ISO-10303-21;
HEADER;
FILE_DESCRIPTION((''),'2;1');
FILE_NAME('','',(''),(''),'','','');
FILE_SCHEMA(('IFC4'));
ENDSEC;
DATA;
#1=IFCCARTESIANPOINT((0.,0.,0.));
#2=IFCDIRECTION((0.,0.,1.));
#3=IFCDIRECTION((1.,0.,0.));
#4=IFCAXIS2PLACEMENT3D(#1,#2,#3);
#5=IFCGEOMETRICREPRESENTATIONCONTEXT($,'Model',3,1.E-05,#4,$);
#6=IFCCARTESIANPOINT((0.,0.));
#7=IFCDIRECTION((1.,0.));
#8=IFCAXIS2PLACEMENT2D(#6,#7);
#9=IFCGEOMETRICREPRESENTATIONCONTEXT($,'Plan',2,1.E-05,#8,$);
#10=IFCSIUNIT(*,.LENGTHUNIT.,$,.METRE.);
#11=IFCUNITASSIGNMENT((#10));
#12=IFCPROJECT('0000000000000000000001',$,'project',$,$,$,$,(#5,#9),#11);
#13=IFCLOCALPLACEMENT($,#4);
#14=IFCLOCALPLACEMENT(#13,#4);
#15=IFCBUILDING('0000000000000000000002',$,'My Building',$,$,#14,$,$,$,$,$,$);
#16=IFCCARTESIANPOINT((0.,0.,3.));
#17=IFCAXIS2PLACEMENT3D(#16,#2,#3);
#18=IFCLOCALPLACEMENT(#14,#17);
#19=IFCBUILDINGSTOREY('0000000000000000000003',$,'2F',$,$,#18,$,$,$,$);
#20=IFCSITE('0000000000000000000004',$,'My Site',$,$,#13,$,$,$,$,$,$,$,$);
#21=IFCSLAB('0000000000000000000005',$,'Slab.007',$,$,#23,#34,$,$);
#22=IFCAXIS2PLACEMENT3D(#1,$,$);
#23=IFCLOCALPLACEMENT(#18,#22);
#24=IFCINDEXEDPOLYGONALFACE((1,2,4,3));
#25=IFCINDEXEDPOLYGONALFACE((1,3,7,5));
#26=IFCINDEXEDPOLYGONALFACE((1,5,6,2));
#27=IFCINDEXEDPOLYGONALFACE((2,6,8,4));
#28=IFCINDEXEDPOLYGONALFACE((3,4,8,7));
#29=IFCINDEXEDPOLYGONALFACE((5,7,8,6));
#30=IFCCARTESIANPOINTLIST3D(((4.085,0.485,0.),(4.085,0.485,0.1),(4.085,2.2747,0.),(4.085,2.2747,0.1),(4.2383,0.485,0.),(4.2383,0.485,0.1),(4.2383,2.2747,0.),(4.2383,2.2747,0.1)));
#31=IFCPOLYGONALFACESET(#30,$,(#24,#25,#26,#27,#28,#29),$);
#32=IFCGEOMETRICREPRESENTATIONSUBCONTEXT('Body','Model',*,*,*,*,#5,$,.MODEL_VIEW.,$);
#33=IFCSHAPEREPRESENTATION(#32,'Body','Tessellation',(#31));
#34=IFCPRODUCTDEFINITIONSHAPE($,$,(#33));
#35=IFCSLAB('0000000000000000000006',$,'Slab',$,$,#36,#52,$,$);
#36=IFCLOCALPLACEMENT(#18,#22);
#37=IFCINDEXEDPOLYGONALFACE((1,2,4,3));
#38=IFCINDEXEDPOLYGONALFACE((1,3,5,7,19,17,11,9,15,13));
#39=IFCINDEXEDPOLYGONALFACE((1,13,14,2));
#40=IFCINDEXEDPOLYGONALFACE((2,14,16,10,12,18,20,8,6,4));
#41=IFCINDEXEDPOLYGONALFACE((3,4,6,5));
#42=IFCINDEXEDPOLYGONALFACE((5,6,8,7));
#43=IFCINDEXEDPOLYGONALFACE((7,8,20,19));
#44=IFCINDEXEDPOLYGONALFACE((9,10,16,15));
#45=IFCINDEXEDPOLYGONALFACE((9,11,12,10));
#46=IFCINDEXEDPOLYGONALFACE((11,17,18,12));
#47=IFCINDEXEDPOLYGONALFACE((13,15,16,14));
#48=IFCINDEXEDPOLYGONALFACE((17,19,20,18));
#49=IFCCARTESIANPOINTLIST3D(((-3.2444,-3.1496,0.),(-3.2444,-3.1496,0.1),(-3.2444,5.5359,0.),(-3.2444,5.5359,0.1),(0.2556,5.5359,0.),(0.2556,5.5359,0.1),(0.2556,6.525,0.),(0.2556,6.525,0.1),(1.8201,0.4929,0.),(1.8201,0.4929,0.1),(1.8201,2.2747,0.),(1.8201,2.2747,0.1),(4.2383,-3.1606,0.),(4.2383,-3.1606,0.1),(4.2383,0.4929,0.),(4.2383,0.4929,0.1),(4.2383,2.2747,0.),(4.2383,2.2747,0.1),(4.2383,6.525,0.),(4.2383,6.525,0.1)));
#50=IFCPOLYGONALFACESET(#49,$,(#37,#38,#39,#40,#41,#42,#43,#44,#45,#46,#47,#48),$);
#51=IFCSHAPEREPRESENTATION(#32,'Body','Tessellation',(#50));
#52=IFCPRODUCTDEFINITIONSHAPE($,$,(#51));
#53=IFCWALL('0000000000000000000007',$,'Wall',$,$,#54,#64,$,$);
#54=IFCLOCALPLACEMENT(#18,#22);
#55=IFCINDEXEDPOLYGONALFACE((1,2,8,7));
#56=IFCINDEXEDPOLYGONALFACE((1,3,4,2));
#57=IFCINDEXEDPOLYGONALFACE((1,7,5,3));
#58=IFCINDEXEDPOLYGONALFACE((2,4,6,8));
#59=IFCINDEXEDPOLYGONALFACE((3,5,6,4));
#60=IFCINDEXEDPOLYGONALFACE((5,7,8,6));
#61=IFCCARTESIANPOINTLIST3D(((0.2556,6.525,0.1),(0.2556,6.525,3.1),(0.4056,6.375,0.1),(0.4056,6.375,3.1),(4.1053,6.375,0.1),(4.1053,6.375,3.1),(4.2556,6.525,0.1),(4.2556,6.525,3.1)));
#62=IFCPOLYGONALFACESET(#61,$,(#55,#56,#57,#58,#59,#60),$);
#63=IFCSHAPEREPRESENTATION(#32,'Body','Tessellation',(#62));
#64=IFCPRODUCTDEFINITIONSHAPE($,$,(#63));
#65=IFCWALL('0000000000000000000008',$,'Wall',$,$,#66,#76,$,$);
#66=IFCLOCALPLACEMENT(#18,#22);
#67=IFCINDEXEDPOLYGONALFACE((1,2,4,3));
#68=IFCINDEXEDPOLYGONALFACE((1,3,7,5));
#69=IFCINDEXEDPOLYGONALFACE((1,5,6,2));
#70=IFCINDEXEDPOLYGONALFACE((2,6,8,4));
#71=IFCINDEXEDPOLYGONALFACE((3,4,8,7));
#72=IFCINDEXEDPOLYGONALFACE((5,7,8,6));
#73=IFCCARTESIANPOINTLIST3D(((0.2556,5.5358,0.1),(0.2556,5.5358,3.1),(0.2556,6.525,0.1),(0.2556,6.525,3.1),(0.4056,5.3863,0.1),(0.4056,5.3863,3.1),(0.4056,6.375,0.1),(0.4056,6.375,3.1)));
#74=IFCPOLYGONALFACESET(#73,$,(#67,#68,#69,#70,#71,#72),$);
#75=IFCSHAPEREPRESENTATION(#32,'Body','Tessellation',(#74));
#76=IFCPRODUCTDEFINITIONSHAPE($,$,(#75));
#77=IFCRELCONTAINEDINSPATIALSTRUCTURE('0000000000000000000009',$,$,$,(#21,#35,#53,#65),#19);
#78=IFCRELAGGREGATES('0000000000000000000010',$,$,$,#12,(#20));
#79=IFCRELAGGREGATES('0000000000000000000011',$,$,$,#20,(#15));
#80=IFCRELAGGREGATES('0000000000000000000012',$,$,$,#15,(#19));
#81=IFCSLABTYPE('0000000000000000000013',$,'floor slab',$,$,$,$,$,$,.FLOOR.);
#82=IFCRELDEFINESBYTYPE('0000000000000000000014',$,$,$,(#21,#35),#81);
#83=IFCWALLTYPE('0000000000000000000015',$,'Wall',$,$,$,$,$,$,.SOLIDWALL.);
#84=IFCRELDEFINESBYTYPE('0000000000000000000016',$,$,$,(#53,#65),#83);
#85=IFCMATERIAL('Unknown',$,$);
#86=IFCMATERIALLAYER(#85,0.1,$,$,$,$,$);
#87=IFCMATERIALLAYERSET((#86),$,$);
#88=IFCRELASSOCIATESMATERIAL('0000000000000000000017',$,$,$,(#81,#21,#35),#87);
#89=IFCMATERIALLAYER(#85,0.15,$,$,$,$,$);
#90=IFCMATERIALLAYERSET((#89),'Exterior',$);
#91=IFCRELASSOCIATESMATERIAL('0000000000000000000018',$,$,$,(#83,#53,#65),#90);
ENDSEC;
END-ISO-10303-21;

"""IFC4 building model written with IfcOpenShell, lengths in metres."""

from ifc_helpers import new_model, si_unit, frame, origin_with_axes, origin_2d_with_axis, place, context, subcontext, project, spatial, line, indexed_curve, outline, extrude, material, layer, layer_set, layer_usage, type_object, element, save


model = new_model("IFC4")

# Units and contexts
model_context = context("Model", 3, precision=1e-05, world=origin_with_axes())
plan_context = context("Plan", 2, precision=1e-05, world=origin_2d_with_axis())
body_context_1 = subcontext(model_context, "Body", "Model", "MODEL_VIEW")
ifc_project = project(units=[si_unit("LENGTHUNIT", "METRE")], contexts=[model_context, plan_context])

# Site, building, storey
site_placement = place(None, origin_with_axes())
site = spatial("IfcSite", under=ifc_project, at=site_placement, Name="My Site")
building_placement = place(site_placement, origin_with_axes())
building = spatial("IfcBuilding", under=site, at=building_placement, Name="My Building")
storey_placement = place(building_placement, frame((0.0, 0.0, 3.0), z_axis=(0.0, 0.0, 1.0), x_axis=(1.0, 0.0, 0.0)))
storey = spatial("IfcBuildingStorey", under=building, at=storey_placement, Name="2F")

# Slabs
ifc_material = material(Name="Unknown")
ifc_layer_1 = layer(ifc_material, 0.1)
ifc_layer_set_1 = layer_set([ifc_layer_1])
ifc_layer_usage_1 = layer_usage(ifc_layer_set_1, "AXIS3", "POSITIVE", -0.1)
slab_type = type_object("IfcSlabType", Name="floor slab", PredefinedType="FLOOR", material=ifc_layer_set_1)
slab_1_placement = place(storey_placement, frame((4.2383, 2.2747, 0.1), z_axis=(0.0, 0.0, 1.0), x_axis=(1.0, 0.0, 0.0)))
element("IfcSlab", 1, at=slab_1_placement, inside=storey, type_object=slab_type, material=ifc_layer_usage_1, Name="Slab.007", context=body_context_1, shape_type="SweptSolid", body=[
    extrude(outline(indexed_curve([(0.0, 0.0), (0.0, -1.7897), (-0.1533, -1.7897), (-0.1533, 0.0), (0.0, 0.0)])), frame((0.0, 0.0, -0.1), z_axis=(0.0, 0.0, 1.0), x_axis=(1.0, 0.0, 0.0)), (0.0, 0.0, 1.0), 0.1),
])
ifc_layer_usage_2 = layer_usage(ifc_layer_set_1, "AXIS3", "POSITIVE", -0.1)
slab_2_placement = place(storey_placement, frame((4.2383, -3.1606, 0.1), z_axis=(0.0, 0.0, 1.0), x_axis=(1.0, 0.0, 0.0)))
element("IfcSlab", 2, at=slab_2_placement, inside=storey, type_object=slab_type, material=ifc_layer_usage_2, Name="Slab", context=body_context_1, shape_type="SweptSolid", body=[
    extrude(outline(indexed_curve([(0.0, 0.0), (0.0, 3.6536), (-2.4183, 3.6536), (-2.4183, 5.4353), (0.0, 5.4353), (0.0, 9.6856), (-3.9827, 9.6856), (-3.9827, 8.6965), (-7.4827, 8.6965), (-7.4827, 0.011), (0.0, 0.0)])), frame((0.0, 0.0, -0.1), z_axis=(0.0, 0.0, 1.0), x_axis=(1.0, 0.0, 0.0)), (0.0, 0.0, 1.0), 0.1),
])

# Walls
ifc_layer_2 = layer(ifc_material, 0.15)
ifc_layer_set_2 = layer_set([ifc_layer_2], Name="Exterior")
ifc_layer_usage_3 = layer_usage(ifc_layer_set_2, "AXIS2", "POSITIVE", 0.0)
wall_type_1 = type_object("IfcWallType", Name="Wall", PredefinedType="SOLIDWALL", material=ifc_layer_set_2)
wall_1_placement = place(storey_placement, frame((4.2556, 6.525, 0.1), z_axis=(0.0, 0.0, 1.0), x_axis=(-1.0, 0.0, 0.0)))
element("IfcWall", 3, at=wall_1_placement, inside=storey, type_object=wall_type_1, material=ifc_layer_usage_3, Name="Wall", context=body_context_1, shape_type="SweptSolid", body=[
    extrude(outline(indexed_curve([(0.0, 0.0), (0.1503, 0.15), (3.85, 0.15), (4.0, 0.0)], segments=[line(1, 2, 3, 4, 1)])), origin_with_axes(), (0.0, 0.0, 1.0), 3.0),
])
ifc_layer_usage_4 = layer_usage(ifc_layer_set_2, "AXIS2", "POSITIVE", 0.0)
wall_2_placement = place(storey_placement, frame((0.2556, 6.525, 0.1), z_axis=(0.0, 0.0, 1.0), x_axis=(0.0, -1.0, 0.0)))
element("IfcWall", 4, at=wall_2_placement, inside=storey, type_object=wall_type_1, material=ifc_layer_usage_4, Name="Wall", context=body_context_1, shape_type="SweptSolid", body=[
    extrude(outline(indexed_curve([(0.0, 0.0), (0.15, 0.15), (1.1387, 0.15), (0.9892, 0.0)], segments=[line(1, 2, 3, 4, 1)])), origin_with_axes(), (0.0, 0.0, 1.0), 3.0),
])

save(model, "model.ifc")
